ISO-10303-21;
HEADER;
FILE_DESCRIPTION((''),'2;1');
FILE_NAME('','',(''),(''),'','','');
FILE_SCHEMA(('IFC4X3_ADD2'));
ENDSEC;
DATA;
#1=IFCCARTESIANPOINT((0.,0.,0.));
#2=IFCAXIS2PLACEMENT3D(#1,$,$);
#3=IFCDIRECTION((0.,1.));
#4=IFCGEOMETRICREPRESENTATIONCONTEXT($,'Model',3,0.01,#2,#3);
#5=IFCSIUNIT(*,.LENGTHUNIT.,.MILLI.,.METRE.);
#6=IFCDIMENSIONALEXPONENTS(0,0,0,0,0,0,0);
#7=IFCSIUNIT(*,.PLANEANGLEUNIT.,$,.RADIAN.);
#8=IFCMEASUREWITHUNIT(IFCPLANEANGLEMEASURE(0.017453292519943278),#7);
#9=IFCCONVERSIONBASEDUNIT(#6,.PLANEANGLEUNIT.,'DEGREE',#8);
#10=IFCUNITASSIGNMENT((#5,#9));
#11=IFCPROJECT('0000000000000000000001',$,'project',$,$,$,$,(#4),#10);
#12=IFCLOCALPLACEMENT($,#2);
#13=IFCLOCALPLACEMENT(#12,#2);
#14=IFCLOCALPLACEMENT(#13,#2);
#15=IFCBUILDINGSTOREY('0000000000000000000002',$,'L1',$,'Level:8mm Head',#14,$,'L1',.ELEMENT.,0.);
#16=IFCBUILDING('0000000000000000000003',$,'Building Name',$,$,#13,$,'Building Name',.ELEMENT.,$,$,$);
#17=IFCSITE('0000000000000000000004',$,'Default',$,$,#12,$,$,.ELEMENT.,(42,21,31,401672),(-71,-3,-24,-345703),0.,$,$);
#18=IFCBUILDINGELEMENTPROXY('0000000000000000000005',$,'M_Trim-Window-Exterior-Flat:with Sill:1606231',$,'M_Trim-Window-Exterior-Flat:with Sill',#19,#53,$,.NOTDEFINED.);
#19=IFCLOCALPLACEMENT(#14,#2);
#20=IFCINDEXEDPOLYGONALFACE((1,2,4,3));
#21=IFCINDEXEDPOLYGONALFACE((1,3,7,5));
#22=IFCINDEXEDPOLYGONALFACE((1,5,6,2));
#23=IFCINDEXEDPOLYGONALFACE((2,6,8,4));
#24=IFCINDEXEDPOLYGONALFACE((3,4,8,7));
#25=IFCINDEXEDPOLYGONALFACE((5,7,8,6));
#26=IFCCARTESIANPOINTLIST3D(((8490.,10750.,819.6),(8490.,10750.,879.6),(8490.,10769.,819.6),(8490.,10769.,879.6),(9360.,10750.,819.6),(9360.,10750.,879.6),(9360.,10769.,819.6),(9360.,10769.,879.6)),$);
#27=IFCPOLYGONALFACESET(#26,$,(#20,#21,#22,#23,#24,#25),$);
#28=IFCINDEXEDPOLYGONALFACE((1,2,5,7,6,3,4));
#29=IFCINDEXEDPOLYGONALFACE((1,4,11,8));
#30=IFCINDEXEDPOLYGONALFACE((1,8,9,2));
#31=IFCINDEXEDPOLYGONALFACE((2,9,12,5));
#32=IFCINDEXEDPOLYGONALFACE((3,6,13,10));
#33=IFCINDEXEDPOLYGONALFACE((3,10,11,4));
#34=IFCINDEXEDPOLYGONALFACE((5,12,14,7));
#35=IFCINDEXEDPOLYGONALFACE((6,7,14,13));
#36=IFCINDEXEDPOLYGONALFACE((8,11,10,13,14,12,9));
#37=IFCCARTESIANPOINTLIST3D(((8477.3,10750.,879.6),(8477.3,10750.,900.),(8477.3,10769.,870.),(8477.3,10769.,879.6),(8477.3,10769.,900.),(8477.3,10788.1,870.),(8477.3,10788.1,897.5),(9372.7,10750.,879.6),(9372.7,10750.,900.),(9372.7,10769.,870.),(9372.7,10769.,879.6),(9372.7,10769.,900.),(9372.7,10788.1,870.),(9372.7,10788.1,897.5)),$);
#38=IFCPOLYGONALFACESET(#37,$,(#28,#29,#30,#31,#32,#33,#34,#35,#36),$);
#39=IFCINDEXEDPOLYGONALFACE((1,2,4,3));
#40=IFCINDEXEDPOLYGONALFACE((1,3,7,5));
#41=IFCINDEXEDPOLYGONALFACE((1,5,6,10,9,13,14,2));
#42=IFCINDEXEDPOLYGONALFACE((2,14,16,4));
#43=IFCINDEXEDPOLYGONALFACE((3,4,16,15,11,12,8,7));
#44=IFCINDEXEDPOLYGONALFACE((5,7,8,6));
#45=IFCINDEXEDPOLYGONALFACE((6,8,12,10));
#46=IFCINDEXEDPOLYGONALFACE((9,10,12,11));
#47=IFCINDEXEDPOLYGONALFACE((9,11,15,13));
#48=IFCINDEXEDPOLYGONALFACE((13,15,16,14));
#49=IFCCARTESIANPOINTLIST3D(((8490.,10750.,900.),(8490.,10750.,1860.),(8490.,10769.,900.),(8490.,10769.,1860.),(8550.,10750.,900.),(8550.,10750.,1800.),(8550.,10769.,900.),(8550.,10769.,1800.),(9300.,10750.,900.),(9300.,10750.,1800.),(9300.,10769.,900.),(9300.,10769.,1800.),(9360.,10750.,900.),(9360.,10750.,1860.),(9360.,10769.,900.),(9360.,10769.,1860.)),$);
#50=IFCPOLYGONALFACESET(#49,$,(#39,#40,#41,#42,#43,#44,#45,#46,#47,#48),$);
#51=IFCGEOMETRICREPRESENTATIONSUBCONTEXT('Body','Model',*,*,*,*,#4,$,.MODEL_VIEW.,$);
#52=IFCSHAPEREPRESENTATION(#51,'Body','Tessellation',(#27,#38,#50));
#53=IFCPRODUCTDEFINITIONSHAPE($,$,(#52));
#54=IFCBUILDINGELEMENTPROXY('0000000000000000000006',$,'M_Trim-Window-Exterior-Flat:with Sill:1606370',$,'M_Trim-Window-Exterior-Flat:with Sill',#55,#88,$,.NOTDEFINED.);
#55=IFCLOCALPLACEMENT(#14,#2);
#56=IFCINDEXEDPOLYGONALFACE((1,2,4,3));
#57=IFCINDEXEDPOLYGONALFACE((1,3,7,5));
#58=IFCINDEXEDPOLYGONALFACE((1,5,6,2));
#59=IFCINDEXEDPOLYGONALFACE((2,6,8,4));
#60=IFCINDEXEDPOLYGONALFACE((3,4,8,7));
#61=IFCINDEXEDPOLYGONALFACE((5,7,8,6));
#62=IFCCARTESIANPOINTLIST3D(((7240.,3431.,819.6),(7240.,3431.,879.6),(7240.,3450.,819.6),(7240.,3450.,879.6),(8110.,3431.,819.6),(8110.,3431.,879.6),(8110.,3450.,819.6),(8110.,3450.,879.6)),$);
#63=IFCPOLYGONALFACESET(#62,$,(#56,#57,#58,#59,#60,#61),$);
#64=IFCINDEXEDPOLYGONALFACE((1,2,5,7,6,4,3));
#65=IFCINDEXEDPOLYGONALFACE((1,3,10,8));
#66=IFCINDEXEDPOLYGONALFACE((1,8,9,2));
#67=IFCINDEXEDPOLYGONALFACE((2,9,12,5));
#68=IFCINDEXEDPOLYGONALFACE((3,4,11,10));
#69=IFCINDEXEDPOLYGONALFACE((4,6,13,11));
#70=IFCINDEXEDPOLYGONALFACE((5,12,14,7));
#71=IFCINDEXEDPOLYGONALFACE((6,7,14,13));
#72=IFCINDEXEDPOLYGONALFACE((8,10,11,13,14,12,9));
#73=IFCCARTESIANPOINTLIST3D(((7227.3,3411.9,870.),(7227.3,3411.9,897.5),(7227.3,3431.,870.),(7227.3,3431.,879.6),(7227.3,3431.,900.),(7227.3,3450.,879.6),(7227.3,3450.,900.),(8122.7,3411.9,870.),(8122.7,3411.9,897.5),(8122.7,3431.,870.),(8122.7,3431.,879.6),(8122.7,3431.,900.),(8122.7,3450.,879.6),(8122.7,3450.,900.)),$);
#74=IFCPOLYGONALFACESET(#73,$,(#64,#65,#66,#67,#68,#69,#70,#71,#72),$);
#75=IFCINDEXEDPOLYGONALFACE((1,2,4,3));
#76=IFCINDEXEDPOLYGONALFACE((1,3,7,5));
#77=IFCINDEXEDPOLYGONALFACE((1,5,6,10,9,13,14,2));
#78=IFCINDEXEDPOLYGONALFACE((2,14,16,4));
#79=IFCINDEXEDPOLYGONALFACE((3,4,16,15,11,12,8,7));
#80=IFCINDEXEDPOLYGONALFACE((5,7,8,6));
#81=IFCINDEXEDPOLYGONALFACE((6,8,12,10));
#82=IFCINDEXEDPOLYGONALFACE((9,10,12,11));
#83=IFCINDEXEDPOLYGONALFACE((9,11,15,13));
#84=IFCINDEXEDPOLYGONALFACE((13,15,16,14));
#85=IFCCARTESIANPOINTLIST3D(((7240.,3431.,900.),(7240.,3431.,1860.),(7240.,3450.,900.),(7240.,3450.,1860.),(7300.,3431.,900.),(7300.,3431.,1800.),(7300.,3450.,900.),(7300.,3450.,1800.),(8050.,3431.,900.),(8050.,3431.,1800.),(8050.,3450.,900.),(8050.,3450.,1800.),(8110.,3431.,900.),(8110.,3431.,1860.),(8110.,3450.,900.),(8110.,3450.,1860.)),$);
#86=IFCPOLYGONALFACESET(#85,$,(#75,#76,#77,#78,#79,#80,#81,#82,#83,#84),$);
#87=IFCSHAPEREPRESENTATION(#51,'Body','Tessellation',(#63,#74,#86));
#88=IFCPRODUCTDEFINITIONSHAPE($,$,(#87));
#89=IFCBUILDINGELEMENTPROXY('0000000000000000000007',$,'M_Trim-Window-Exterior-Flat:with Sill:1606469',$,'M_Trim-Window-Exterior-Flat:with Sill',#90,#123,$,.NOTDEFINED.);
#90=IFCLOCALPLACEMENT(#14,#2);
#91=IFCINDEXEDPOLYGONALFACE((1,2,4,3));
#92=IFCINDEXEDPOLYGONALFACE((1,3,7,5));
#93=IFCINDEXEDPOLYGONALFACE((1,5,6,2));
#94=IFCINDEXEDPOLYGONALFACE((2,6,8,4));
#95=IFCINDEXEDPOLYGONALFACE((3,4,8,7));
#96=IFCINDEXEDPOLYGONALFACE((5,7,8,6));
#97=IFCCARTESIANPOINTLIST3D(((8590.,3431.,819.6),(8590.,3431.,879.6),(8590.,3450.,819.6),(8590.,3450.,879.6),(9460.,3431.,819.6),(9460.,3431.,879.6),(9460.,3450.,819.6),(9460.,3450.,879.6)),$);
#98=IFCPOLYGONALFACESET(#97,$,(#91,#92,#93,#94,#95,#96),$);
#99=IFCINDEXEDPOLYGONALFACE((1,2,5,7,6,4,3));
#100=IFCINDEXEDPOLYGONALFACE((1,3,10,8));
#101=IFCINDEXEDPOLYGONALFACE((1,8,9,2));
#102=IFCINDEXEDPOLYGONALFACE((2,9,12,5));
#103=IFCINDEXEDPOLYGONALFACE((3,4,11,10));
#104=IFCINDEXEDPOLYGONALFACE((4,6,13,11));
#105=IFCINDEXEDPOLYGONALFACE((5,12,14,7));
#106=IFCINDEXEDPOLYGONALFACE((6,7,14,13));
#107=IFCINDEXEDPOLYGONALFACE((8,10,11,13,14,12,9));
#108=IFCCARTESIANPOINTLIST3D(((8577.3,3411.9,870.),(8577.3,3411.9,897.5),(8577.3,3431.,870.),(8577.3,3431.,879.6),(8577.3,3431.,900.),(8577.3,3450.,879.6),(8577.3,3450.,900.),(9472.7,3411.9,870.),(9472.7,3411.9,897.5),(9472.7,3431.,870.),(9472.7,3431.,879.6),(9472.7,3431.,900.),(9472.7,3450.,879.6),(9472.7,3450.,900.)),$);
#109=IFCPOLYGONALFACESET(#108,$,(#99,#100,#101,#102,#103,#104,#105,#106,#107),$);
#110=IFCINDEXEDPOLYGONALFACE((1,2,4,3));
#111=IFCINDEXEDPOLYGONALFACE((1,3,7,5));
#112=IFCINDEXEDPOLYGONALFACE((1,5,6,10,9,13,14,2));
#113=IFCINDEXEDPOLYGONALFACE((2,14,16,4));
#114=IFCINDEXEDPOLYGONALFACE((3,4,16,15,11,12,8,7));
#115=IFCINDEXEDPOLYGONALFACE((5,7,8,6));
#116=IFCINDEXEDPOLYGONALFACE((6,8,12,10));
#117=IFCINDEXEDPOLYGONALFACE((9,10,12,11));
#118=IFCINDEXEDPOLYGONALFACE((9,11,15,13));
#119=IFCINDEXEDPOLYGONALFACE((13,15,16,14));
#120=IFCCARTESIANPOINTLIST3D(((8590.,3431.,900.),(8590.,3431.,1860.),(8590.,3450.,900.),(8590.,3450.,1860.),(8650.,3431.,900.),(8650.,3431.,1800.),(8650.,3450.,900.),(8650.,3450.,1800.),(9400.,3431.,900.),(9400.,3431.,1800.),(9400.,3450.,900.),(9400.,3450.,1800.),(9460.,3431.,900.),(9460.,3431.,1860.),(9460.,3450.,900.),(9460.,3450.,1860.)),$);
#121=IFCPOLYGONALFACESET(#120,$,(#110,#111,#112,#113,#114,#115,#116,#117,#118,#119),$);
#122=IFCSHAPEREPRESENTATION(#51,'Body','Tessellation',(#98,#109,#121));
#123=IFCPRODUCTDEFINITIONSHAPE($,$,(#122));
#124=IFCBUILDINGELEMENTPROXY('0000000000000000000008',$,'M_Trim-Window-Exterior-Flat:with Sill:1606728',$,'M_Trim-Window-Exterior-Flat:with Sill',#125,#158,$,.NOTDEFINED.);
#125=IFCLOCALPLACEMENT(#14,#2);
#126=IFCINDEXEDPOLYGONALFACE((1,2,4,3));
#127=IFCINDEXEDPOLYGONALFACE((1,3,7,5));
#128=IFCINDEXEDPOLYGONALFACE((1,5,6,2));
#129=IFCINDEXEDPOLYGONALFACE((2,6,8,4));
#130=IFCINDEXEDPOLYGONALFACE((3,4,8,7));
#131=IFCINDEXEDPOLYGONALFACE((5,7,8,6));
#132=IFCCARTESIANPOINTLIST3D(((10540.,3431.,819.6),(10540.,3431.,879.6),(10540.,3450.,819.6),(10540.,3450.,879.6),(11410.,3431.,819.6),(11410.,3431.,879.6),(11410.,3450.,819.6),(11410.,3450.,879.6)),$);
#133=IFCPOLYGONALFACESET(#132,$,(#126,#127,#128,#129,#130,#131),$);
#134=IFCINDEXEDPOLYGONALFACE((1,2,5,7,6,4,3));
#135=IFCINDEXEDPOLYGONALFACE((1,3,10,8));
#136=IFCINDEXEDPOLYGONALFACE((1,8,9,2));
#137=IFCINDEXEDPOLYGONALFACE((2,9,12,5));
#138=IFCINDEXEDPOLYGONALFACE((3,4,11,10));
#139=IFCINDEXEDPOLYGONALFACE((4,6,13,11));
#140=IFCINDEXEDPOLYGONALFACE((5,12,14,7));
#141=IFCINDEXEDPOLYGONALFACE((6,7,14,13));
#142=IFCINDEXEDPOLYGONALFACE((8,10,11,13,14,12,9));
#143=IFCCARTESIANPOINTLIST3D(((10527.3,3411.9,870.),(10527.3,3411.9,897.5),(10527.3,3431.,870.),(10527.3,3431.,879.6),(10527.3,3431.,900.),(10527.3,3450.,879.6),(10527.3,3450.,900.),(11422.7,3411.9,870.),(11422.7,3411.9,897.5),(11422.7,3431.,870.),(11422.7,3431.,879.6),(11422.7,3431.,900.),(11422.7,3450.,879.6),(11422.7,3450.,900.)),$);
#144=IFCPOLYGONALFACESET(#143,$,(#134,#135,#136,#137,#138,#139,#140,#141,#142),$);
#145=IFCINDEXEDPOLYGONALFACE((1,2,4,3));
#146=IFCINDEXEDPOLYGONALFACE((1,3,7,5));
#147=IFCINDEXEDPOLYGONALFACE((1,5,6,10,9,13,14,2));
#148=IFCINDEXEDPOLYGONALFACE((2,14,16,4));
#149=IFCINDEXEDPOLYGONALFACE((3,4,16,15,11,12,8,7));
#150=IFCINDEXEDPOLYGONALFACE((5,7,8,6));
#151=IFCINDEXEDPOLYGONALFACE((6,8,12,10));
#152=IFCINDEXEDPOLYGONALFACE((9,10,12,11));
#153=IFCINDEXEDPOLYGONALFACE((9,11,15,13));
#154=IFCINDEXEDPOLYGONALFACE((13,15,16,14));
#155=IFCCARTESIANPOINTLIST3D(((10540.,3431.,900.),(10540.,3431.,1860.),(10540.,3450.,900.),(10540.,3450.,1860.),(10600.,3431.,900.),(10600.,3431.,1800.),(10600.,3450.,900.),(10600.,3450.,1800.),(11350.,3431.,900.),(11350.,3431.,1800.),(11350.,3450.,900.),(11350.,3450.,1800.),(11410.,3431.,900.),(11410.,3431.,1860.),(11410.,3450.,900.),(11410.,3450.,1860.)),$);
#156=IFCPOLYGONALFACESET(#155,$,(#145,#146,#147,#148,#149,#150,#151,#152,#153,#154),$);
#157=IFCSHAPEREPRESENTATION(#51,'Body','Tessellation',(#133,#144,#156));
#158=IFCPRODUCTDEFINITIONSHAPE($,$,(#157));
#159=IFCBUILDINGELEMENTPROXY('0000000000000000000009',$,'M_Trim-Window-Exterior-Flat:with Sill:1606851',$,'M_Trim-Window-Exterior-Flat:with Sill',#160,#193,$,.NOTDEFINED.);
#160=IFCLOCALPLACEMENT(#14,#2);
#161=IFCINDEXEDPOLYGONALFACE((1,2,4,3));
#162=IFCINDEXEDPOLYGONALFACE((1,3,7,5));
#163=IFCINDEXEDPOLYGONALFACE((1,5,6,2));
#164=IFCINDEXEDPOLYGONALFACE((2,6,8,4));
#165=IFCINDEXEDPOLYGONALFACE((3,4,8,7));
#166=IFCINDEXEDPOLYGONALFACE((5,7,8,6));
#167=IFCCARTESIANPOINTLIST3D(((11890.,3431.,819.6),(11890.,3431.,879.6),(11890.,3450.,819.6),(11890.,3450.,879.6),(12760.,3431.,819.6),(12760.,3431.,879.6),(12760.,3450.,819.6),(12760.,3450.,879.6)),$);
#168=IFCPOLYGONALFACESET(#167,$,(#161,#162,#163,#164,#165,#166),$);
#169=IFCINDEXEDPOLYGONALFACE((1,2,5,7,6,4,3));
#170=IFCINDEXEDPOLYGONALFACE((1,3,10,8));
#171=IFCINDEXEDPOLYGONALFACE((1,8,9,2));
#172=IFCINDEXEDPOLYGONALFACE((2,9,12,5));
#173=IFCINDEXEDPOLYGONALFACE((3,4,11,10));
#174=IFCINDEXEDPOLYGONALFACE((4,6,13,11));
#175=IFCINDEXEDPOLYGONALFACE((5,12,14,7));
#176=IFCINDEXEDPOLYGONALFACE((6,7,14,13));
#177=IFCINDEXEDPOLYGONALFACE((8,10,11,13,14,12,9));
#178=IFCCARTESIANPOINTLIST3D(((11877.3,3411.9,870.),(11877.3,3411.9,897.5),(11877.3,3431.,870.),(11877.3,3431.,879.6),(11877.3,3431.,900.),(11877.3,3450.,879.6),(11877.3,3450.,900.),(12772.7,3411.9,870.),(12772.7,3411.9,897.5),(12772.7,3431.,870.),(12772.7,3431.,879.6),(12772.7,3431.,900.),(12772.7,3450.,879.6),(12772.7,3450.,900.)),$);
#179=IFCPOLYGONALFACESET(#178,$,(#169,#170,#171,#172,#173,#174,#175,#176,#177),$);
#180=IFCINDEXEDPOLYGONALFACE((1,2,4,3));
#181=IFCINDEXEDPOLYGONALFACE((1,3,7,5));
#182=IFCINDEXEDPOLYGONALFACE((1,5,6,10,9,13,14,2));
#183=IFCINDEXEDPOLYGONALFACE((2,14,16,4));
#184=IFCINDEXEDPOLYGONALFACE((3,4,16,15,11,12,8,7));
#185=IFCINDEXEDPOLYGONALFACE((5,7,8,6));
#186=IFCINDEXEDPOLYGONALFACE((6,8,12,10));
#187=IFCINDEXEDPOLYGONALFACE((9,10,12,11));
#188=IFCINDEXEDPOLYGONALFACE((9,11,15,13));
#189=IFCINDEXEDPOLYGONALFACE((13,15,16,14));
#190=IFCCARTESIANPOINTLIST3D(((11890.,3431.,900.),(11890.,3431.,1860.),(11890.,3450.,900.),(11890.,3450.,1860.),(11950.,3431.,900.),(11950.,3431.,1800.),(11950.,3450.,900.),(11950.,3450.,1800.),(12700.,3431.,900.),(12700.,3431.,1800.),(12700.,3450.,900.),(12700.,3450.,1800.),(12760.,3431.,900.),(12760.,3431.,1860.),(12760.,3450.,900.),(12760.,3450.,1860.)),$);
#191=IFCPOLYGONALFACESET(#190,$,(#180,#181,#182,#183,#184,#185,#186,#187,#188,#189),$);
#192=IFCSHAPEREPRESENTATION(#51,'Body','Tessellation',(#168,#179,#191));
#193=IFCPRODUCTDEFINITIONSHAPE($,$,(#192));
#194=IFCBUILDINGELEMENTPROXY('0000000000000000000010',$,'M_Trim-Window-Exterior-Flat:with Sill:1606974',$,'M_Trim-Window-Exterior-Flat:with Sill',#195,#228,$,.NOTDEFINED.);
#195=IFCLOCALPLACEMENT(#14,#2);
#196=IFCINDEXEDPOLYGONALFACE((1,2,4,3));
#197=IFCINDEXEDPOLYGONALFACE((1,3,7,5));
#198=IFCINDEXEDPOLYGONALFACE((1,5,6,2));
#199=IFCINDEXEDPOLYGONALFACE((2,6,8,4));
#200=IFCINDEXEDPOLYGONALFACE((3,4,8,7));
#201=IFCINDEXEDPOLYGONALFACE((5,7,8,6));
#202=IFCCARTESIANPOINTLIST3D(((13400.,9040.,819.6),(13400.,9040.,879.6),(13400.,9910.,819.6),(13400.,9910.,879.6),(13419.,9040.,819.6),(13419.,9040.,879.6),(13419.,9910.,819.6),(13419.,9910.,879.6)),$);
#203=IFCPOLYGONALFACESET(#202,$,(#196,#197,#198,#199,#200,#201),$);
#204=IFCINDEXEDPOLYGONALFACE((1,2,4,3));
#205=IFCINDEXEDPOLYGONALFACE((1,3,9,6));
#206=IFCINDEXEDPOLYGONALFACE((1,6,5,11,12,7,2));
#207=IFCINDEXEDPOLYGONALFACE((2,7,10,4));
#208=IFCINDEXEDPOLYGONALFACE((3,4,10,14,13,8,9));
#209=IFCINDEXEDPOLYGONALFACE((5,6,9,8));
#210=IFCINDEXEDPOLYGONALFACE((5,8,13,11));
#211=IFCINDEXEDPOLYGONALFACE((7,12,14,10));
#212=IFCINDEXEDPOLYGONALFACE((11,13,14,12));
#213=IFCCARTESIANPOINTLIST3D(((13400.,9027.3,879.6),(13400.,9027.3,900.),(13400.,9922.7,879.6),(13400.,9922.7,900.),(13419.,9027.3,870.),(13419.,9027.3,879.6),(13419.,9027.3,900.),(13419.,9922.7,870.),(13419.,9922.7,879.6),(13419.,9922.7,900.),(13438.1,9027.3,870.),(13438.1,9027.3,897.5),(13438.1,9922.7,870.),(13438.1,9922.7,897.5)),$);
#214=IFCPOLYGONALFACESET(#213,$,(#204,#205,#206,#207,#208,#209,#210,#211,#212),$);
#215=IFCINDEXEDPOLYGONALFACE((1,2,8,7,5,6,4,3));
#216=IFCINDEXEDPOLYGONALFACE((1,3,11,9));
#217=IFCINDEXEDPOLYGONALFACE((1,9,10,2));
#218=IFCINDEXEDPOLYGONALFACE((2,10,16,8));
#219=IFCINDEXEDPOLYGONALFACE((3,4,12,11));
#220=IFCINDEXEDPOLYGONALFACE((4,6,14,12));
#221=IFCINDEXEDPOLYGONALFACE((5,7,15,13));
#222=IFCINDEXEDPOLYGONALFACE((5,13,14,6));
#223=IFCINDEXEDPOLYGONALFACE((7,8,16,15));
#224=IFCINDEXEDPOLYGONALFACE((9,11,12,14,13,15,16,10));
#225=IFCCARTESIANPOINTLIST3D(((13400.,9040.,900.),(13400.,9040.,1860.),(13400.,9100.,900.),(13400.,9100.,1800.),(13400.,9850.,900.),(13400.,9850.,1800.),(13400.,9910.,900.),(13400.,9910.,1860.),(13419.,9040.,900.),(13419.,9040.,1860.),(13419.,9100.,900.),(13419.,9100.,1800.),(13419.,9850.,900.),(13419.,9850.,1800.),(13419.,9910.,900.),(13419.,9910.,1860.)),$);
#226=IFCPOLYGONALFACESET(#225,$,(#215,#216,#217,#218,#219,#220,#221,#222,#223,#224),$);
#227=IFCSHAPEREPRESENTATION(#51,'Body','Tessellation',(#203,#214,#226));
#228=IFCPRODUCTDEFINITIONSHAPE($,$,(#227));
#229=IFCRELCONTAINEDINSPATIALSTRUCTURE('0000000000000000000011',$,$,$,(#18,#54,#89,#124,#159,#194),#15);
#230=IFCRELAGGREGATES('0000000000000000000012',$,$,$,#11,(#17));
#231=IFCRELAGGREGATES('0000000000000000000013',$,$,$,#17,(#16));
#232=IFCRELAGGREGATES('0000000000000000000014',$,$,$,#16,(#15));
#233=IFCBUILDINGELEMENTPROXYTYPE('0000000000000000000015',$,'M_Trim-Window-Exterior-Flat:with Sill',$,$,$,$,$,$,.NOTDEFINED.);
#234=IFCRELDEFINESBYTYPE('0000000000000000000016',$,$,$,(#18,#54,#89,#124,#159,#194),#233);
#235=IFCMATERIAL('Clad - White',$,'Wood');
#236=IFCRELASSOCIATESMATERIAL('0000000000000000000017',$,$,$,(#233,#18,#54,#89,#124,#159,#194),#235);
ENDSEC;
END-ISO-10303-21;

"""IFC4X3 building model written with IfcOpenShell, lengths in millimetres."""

from ifc_helpers import new_model, entity, si_unit, converted_unit, direction, frame, frame_2d, origin, place, context, subcontext, project, spatial, polyline, rectangle, outline, extrude, source, transform, mapped, material, type_object, type_shapes, element, save


model = new_model("IFC4X3")

# Units and contexts
model_context = context("Model", 3, precision=0.01, world=origin(), true_north=direction((0.0, 1.0)))
body_context = subcontext(model_context, "Body", "Model", "MODEL_VIEW")
ifc_project = project(units=[si_unit("LENGTHUNIT", "METRE", prefix="MILLI"), converted_unit("PLANEANGLEUNIT", "DEGREE", entity("IfcPlaneAngleMeasure", 0.017453292519943278), si_unit("PLANEANGLEUNIT", "RADIAN"), dimensions=[0, 0, 0, 0, 0, 0, 0])], contexts=[model_context])

# Site, building, storey
site_placement = place(None, origin())
site = spatial("IfcSite", under=ifc_project, at=site_placement, Name="Default", CompositionType="ELEMENT", RefLatitude=(42, 21, 31, 401672), RefLongitude=(-71, -3, -24, -345703), RefElevation=0.0)
building_placement = place(site_placement, origin())
building = spatial("IfcBuilding", under=site, at=building_placement, Name="Building Name", LongName="Building Name", CompositionType="ELEMENT")
storey_placement = place(building_placement, origin())
storey = spatial("IfcBuildingStorey", under=building, at=storey_placement, Name="L1", ObjectType="Level:8mm Head", LongName="L1", CompositionType="ELEMENT", Elevation=0.0)

# Building element proxies
ifc_material_1 = material(Name="Clad - White", Category="Wood")
building_element_proxy_type_1 = type_object("IfcBuildingElementProxyType", Name="M_Trim-Window-Exterior-Flat:with Sill", PredefinedType="NOTDEFINED", material=ifc_material_1)
shared_shape_1 = source(origin(), body_context, "Body", "SweptSolid", [
    extrude(rectangle(XDim=870.0, YDim=60.0, at=frame_2d((0.0, 0.0), x_axis=(1.0, 0.0))), frame((0.0, -950.4, 0.0), z_axis=(0.0, 0.0, 1.0), x_axis=(-1.0, 0.0, 0.0)), (0.0, 0.0, 1.0), 19.0),
    extrude(outline(polyline([(-19.0, -15.2), (0.0, -15.2), (0.0, -5.7), (19.0, -5.7), (19.0, 14.8), (0.0, 14.8), (-19.0, 12.3), (-19.0, -15.2)])), frame((-447.7, -914.8, 19.0), z_axis=(1.0, 0.0, 0.0), x_axis=(0.0, 0.0, -1.0)), (0.0, 0.0, 1.0), 895.4),
    extrude(outline(polyline([(-495.0, -435.0), (465.0, -435.0), (465.0, -375.0), (-435.0, -375.0), (-435.0, 375.0), (465.0, 375.0), (465.0, 435.0), (-495.0, 435.0), (-495.0, -435.0)])), frame((0.0, -435.0, 0.0), z_axis=(0.0, 0.0, 1.0), x_axis=(0.0, -1.0, 0.0)), (0.0, 0.0, 1.0), 19.0),
])
type_shapes(building_element_proxy_type_1, [shared_shape_1])
for number, where, z_axis, x_axis, name in (
    (1, (8925.0, 10750.0, 1800.0), (0.0, 1.0, 0.0), (-1.0, 0.0, 0.0), "M_Trim-Window-Exterior-Flat:with Sill:1606231"),
    (2, (7675.0, 3450.0, 1800.0), (0.0, -1.0, 0.0), (1.0, 0.0, 0.0), "M_Trim-Window-Exterior-Flat:with Sill:1606370"),
    (3, (9025.0, 3450.0, 1800.0), (0.0, -1.0, 0.0), (1.0, 0.0, 0.0), "M_Trim-Window-Exterior-Flat:with Sill:1606469"),
    (4, (10975.0, 3450.0, 1800.0), (0.0, -1.0, 0.0), (1.0, 0.0, 0.0), "M_Trim-Window-Exterior-Flat:with Sill:1606728"),
    (5, (12325.0, 3450.0, 1800.0), (0.0, -1.0, 0.0), (1.0, 0.0, 0.0), "M_Trim-Window-Exterior-Flat:with Sill:1606851"),
    (6, (13400.0, 9475.0, 1800.0), (1.0, 0.0, 0.0), (0.0, 1.0, 0.0), "M_Trim-Window-Exterior-Flat:with Sill:1606974"),
):
    element("IfcBuildingElementProxy", number, at=place(storey_placement, frame(where, z_axis=z_axis, x_axis=x_axis)), inside=storey, type_object=building_element_proxy_type_1, material=ifc_material_1, Name=name, ObjectType="M_Trim-Window-Exterior-Flat:with Sill", PredefinedType="NOTDEFINED", context=body_context, shape_type="MappedRepresentation", body=[
        mapped(shared_shape_1, transform((0.0, 0.0, 0.0), scale=1.0)),
    ])

save(model, "model.ifc")
